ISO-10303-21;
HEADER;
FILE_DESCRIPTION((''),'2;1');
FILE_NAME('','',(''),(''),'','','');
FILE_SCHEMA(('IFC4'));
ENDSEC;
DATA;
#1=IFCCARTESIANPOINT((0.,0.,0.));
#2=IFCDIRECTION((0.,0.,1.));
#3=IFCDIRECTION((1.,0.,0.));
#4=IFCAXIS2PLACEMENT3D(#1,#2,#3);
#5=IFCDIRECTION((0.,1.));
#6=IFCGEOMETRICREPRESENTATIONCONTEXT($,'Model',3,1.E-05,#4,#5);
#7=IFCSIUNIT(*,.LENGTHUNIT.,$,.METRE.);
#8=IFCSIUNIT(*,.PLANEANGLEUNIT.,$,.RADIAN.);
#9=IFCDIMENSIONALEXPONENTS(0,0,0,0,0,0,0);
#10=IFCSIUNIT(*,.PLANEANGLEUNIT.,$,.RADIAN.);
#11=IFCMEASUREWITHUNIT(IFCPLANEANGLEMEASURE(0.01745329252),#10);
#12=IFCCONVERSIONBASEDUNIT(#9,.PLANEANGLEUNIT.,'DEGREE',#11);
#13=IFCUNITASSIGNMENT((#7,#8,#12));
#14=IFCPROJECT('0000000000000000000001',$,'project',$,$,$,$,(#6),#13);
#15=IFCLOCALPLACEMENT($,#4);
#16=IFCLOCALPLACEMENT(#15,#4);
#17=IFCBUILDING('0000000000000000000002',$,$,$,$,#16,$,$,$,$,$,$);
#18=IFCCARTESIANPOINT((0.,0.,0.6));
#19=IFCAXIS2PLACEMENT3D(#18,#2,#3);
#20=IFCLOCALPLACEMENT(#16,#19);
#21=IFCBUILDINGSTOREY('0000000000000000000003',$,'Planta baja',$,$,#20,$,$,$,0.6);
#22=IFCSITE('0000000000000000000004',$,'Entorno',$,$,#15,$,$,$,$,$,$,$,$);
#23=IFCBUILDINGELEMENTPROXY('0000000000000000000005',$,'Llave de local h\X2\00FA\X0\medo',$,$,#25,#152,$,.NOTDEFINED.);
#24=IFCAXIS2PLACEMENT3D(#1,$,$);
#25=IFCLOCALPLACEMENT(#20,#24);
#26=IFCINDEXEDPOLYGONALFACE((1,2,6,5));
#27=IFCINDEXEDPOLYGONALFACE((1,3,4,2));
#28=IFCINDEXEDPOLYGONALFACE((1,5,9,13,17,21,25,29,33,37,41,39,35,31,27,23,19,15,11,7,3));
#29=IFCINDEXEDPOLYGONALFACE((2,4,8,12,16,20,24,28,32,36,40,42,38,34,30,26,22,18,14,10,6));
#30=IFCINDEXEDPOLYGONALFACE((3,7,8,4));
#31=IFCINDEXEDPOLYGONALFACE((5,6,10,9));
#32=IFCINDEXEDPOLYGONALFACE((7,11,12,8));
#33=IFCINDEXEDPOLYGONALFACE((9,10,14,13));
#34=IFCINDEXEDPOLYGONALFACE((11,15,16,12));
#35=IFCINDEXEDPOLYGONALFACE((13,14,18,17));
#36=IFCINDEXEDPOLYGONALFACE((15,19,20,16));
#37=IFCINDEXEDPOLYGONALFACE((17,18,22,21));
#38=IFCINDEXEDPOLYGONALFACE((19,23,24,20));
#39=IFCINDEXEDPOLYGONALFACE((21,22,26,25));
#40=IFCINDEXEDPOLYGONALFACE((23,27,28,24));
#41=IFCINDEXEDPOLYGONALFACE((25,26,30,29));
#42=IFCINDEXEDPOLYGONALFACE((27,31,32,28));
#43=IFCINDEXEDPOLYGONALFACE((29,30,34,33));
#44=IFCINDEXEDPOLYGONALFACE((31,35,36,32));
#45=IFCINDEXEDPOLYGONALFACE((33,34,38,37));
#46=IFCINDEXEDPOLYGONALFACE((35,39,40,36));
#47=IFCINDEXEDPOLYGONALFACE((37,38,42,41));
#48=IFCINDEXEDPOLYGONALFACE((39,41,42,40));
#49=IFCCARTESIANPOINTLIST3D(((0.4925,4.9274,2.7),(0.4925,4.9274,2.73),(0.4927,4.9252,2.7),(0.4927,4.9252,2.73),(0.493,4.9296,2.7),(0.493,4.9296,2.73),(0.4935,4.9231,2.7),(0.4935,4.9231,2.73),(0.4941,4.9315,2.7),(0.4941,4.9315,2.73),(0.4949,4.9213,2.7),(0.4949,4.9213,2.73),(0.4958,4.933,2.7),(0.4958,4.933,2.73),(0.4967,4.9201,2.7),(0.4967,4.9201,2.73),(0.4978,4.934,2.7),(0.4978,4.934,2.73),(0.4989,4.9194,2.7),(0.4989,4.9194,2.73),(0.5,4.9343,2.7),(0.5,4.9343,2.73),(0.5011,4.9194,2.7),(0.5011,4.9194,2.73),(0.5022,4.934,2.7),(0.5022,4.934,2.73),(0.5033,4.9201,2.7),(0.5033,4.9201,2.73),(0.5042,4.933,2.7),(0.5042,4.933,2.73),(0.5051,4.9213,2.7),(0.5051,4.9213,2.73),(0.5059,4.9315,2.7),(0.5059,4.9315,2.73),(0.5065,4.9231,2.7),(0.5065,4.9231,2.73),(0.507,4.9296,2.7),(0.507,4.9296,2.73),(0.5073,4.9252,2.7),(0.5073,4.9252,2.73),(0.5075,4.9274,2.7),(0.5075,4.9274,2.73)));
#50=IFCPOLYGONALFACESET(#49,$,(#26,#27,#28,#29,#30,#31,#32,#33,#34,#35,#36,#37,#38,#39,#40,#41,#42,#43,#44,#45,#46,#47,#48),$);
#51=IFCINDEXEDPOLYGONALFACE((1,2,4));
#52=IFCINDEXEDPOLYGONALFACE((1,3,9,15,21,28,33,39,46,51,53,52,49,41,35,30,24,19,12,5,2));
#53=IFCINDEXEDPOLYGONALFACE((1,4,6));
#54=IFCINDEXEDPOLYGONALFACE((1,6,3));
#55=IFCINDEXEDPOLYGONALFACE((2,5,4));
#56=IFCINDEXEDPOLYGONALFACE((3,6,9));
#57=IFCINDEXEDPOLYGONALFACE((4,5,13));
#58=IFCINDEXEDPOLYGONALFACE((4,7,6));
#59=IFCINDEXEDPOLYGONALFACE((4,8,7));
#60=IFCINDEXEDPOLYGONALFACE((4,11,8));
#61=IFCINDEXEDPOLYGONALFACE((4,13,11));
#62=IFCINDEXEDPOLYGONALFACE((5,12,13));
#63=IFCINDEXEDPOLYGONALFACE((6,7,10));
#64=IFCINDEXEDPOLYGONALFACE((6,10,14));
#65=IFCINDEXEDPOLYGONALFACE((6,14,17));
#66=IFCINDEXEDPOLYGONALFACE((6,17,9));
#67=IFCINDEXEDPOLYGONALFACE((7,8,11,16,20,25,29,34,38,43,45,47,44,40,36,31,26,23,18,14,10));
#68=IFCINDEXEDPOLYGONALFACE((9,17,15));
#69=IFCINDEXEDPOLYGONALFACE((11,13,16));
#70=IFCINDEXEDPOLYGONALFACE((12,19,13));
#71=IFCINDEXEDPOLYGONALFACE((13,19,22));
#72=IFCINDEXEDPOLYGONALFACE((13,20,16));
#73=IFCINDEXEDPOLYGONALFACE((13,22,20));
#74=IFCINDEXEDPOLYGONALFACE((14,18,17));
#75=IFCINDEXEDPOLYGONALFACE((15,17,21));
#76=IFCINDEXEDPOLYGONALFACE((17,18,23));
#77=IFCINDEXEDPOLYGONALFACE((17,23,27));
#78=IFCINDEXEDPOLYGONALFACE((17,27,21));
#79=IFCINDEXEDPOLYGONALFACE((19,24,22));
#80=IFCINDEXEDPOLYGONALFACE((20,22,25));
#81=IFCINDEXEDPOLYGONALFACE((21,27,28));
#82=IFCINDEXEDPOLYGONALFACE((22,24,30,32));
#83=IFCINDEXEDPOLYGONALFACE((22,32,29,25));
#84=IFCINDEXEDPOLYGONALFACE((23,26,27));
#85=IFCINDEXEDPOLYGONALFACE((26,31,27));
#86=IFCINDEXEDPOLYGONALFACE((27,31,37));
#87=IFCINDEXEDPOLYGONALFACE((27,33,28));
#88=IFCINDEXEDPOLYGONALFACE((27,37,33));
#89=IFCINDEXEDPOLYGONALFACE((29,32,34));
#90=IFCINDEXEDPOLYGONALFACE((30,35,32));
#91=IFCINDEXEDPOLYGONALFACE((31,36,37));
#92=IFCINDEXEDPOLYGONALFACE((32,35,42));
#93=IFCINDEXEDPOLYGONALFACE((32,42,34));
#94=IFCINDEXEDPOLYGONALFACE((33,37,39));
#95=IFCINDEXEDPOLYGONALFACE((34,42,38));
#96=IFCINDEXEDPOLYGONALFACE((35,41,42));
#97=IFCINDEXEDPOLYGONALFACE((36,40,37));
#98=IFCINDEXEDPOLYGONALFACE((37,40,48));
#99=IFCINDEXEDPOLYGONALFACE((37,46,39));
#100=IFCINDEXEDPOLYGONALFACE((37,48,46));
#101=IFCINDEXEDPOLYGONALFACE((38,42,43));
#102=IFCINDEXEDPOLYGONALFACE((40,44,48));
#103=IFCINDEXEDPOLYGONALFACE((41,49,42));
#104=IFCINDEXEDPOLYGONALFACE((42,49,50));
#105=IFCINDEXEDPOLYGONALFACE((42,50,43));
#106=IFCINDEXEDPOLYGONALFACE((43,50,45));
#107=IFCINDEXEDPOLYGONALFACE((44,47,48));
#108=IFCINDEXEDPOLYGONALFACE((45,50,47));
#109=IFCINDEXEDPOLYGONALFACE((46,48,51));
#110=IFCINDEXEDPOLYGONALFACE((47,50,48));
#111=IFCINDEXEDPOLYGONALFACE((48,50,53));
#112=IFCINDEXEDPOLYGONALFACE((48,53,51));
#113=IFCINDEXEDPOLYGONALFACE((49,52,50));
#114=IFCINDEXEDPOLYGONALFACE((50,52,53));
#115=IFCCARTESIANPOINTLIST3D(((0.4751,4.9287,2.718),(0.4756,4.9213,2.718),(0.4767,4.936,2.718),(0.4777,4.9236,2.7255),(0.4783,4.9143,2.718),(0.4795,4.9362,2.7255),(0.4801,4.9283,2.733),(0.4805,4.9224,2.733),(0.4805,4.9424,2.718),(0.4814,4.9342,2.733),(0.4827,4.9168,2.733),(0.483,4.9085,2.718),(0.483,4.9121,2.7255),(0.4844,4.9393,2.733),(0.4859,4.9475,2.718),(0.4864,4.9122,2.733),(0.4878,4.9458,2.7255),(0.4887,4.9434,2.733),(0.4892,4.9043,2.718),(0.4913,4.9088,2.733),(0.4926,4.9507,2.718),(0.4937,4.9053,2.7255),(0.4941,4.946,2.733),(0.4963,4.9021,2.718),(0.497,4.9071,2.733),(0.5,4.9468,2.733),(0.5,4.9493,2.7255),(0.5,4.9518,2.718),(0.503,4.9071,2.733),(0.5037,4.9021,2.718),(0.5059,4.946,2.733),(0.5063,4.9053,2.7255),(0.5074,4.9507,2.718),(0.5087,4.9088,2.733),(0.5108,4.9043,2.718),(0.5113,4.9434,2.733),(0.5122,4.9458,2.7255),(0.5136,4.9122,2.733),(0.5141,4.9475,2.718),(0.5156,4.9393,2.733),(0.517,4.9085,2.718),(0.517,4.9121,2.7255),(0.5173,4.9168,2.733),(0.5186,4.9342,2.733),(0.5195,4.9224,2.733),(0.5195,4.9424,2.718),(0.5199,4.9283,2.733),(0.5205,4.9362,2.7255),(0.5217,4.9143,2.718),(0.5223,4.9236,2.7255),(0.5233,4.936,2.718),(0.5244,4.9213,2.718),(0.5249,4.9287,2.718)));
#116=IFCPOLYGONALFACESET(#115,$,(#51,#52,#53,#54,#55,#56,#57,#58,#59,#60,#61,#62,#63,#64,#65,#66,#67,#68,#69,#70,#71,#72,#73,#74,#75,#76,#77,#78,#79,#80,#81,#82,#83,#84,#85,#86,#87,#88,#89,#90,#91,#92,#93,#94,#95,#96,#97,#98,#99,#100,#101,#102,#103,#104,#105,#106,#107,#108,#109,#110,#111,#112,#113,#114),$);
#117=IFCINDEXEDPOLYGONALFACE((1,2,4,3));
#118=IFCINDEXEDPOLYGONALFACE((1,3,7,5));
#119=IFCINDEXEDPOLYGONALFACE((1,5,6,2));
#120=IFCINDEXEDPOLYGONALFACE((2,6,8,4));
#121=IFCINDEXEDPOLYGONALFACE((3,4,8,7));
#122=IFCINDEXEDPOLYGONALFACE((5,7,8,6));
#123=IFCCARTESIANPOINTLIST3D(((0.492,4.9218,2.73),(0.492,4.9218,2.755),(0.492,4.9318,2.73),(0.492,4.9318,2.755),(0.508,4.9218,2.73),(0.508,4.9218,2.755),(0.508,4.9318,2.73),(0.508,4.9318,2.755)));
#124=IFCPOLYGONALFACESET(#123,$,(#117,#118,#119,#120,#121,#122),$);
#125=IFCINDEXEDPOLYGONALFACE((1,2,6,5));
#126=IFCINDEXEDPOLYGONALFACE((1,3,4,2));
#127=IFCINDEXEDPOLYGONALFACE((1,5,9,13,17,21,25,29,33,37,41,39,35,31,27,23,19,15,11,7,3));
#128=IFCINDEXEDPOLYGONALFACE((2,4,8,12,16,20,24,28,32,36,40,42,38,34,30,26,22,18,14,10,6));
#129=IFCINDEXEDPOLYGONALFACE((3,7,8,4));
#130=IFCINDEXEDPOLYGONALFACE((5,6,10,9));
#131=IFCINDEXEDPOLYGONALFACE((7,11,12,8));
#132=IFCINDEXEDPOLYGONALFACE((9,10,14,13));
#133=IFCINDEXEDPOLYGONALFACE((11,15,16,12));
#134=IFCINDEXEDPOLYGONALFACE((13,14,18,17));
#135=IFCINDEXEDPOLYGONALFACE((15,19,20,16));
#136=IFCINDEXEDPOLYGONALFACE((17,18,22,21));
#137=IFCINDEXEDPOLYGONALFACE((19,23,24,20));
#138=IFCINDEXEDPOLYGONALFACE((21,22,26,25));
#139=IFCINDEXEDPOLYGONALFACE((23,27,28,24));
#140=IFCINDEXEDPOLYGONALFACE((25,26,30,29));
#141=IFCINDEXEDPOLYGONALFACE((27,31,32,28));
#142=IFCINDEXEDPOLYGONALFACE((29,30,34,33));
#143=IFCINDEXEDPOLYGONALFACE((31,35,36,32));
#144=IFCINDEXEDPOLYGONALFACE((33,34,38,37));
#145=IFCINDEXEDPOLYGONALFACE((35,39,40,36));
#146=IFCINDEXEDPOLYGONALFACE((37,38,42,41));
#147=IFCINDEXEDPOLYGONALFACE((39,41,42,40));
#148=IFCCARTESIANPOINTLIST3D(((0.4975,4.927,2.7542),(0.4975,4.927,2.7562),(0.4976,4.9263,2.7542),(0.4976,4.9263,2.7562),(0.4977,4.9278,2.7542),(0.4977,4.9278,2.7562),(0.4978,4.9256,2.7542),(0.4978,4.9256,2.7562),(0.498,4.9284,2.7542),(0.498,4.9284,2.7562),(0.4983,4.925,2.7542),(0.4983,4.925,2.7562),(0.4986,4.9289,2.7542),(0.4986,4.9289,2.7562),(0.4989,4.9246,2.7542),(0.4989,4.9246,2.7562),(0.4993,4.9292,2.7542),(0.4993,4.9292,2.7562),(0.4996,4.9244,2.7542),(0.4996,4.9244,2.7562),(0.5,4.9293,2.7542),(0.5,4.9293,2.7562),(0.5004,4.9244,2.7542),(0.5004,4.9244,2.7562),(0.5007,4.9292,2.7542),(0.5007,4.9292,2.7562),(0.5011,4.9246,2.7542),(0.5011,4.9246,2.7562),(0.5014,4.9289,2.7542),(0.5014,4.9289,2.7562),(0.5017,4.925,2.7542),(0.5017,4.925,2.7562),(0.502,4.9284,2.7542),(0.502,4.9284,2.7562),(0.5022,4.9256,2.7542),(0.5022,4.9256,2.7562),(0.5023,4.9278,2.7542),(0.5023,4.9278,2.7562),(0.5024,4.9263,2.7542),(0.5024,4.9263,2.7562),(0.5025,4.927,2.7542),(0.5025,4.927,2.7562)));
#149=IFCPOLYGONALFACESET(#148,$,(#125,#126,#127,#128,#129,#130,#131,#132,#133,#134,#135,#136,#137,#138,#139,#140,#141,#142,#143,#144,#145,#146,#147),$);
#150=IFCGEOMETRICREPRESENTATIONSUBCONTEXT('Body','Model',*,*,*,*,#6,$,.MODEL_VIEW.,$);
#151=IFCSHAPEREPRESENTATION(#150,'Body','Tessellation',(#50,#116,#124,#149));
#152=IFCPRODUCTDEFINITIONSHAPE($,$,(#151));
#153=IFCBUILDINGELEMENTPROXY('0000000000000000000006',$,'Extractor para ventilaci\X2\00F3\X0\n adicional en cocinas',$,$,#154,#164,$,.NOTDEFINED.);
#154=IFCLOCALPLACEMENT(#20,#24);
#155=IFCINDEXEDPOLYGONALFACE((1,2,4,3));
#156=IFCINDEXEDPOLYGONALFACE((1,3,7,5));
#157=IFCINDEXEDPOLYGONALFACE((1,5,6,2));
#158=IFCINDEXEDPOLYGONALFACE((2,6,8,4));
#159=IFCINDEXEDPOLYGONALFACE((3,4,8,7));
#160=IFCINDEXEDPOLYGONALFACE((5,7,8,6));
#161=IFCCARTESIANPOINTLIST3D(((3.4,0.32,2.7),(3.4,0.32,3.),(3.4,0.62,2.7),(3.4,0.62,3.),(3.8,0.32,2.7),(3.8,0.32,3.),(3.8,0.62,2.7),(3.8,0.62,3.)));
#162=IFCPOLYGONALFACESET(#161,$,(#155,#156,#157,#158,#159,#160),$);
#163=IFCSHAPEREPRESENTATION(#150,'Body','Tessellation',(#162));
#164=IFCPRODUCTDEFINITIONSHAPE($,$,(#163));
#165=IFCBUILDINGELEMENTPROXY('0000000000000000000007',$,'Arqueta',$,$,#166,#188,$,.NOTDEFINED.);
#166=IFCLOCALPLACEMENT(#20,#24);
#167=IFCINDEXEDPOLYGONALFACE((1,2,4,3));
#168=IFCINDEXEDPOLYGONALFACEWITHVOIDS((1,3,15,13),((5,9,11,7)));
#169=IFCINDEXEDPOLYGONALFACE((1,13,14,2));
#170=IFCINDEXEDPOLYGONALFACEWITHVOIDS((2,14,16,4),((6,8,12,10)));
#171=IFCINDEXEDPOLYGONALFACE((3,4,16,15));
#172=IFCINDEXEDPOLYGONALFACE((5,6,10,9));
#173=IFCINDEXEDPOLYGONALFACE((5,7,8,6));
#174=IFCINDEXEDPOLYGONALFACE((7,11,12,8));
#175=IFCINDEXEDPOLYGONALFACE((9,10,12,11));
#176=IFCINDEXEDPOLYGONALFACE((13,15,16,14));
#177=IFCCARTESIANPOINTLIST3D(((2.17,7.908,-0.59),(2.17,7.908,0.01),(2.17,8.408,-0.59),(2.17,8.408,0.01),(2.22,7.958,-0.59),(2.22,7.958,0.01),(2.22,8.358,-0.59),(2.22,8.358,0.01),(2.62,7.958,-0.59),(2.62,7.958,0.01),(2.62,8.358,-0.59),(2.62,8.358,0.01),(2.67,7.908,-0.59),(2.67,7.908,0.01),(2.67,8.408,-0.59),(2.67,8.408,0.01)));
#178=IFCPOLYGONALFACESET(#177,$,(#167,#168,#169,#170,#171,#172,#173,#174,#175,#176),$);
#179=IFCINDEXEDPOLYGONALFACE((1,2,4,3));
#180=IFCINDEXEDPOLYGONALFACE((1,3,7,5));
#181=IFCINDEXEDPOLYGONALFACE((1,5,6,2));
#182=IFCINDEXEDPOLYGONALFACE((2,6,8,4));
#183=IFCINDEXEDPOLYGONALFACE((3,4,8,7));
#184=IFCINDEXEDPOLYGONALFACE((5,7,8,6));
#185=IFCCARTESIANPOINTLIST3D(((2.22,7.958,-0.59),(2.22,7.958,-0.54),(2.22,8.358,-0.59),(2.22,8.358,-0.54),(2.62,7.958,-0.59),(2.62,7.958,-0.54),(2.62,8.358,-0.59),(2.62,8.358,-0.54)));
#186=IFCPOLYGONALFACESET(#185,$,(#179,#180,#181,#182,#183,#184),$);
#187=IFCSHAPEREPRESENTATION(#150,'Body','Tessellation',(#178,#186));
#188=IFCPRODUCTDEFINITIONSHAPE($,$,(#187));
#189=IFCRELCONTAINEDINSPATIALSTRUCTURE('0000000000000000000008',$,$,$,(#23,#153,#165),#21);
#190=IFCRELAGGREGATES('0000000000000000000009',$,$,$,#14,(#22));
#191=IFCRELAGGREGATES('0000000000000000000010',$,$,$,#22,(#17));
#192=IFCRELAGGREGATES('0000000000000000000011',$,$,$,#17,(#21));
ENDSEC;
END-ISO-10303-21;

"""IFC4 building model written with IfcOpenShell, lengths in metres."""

from ifc_helpers import new_model, entity, si_unit, converted_unit, direction, frame, origin_with_axes, place, context, subcontext, project, spatial, polyline, outline, extrude, element, save


model = new_model("IFC4")

# Units and contexts
model_context = context("Model", 3, precision=1e-05, world=origin_with_axes(), true_north=direction((0.0, 1.0)))
body_context = subcontext(model_context, "Body", "Model", "MODEL_VIEW")
ifc_project = project(units=[si_unit("LENGTHUNIT", "METRE"), si_unit("PLANEANGLEUNIT", "RADIAN"), converted_unit("PLANEANGLEUNIT", "DEGREE", entity("IfcPlaneAngleMeasure", 0.01745329252), si_unit("PLANEANGLEUNIT", "RADIAN"), dimensions=[0, 0, 0, 0, 0, 0, 0])], contexts=[model_context])

# Site, building, storey
site_placement = place(None, origin_with_axes())
site = spatial("IfcSite", under=ifc_project, at=site_placement, Name="Entorno")
building_placement = place(site_placement, origin_with_axes())
building = spatial("IfcBuilding", under=site, at=building_placement)
storey_placement = place(building_placement, frame((0.0, 0.0, 0.6), z_axis=(0.0, 0.0, 1.0), x_axis=(1.0, 0.0, 0.0)))
storey = spatial("IfcBuildingStorey", under=building, at=storey_placement, Name="Planta baja", Elevation=0.6)

# Building element proxies
proxy_1_placement = place(storey_placement, frame((0.0, 0.0, -0.6), z_axis=(0.0, 0.0, 1.0), x_axis=(1.0, 0.0, 0.0)))
ifc_direction_1 = entity("IfcDirection", [0.0, 0.0, 1.0])
ifc_direction_2 = entity("IfcDirection", [0.0, 0.0, 1.0])
ifc_direction_3 = entity("IfcDirection", [0.0, 0.0, 1.0])
element("IfcBuildingElementProxy", 1, at=proxy_1_placement, inside=storey, Name="Llave de local húmedo", PredefinedType="NOTDEFINED", context=body_context, shape_type="Brep", body=[
    entity("IfcExtrudedAreaSolidTapered", entity("IfcCircleProfileDef", "AREA", None, entity("IfcAxis2Placement2D", entity("IfcCartesianPoint", [0.0, 0.0]), entity("IfcDirection", [1.0, 0.0])), 0.0075), entity("IfcAxis2Placement3D", entity("IfcCartesianPoint", [0.5, 4.9268, 3.3]), ifc_direction_1, entity("IfcDirection", [0.0, 1.0, 0.0])), ifc_direction_1, 0.03, entity("IfcCircleProfileDef", "AREA", None, entity("IfcAxis2Placement2D", entity("IfcCartesianPoint", [0.0, 0.0]), entity("IfcDirection", [1.0, 0.0])), 0.0075)),
    entity("IfcExtrudedAreaSolidTapered", entity("IfcCircleProfileDef", "AREA", None, entity("IfcAxis2Placement2D", entity("IfcCartesianPoint", [0.0, 0.0]), entity("IfcDirection", [1.0, 0.0])), 0.025), entity("IfcAxis2Placement3D", entity("IfcCartesianPoint", [0.5, 4.9268, 3.318]), ifc_direction_2, entity("IfcDirection", [0.0, 1.0, 0.0])), ifc_direction_2, 0.015, entity("IfcCircleProfileDef", "AREA", None, entity("IfcAxis2Placement2D", entity("IfcCartesianPoint", [0.0, 0.0]), entity("IfcDirection", [1.0, 0.0])), 0.02)),
    extrude(outline(polyline([(0.005, -0.008), (0.005, 0.008), (-0.005, 0.008), (-0.005, -0.008), (0.005, -0.008)])), frame((0.5, 4.9268, 3.33), z_axis=(0.0, 0.0, 1.0), x_axis=(0.0, 1.0, 0.0)), (0.0, 0.0, 1.0), 0.025),
    entity("IfcExtrudedAreaSolidTapered", entity("IfcCircleProfileDef", "AREA", None, entity("IfcAxis2Placement2D", entity("IfcCartesianPoint", [0.0, 0.0]), entity("IfcDirection", [1.0, 0.0])), 0.0025), entity("IfcAxis2Placement3D", entity("IfcCartesianPoint", [0.5, 4.9268, 3.3542]), ifc_direction_3, entity("IfcDirection", [0.0, 1.0, 0.0])), ifc_direction_3, 0.002, entity("IfcCircleProfileDef", "AREA", None, entity("IfcAxis2Placement2D", entity("IfcCartesianPoint", [0.0, 0.0]), entity("IfcDirection", [1.0, 0.0])), 0.0025)),
])
proxy_2_placement = place(storey_placement, frame((0.0, 0.0, -0.6), z_axis=(0.0, 0.0, 1.0), x_axis=(1.0, 0.0, 0.0)))
element("IfcBuildingElementProxy", 2, at=proxy_2_placement, inside=storey, Name="Extractor para ventilación adicional en cocinas", PredefinedType="NOTDEFINED", context=body_context, shape_type="Brep", body=[
    extrude(outline(polyline([(-0.2, -0.15), (0.2, -0.15), (0.2, 0.15), (-0.2, 0.15), (-0.2, -0.15)])), frame((3.6, 0.47, 3.3), z_axis=(0.0, 0.0, 1.0), x_axis=(-1.0, 0.0, 0.0)), (0.0, 0.0, 1.0), 0.3),
])
proxy_3_placement = place(storey_placement, frame((0.0, 0.0, -0.6), z_axis=(0.0, 0.0, 1.0), x_axis=(1.0, 0.0, 0.0)))
element("IfcBuildingElementProxy", 3, at=proxy_3_placement, inside=storey, Name="Arqueta", PredefinedType="NOTDEFINED", context=body_context, shape_type="Brep", body=[
    extrude(outline(polyline([(-0.25, -0.25), (0.25, -0.25), (0.25, 0.25), (-0.25, 0.25), (-0.25, -0.25)]), holes=[polyline([(-0.2, -0.2), (0.2, -0.2), (0.2, 0.2), (-0.2, 0.2), (-0.2, -0.2)])]), frame((2.42, 8.158, 0.01), z_axis=(0.0, 0.0, 1.0), x_axis=(1.0, 0.0, 0.0)), (0.0, 0.0, 1.0), 0.6),
    extrude(outline(polyline([(-0.2, -0.2), (0.2, -0.2), (0.2, 0.2), (-0.2, 0.2), (-0.2, -0.2)])), frame((2.42, 8.158, 0.01), z_axis=(0.0, 0.0, 1.0), x_axis=(1.0, 0.0, 0.0)), (0.0, 0.0, 1.0), 0.05),
])

save(model, "model.ifc")
